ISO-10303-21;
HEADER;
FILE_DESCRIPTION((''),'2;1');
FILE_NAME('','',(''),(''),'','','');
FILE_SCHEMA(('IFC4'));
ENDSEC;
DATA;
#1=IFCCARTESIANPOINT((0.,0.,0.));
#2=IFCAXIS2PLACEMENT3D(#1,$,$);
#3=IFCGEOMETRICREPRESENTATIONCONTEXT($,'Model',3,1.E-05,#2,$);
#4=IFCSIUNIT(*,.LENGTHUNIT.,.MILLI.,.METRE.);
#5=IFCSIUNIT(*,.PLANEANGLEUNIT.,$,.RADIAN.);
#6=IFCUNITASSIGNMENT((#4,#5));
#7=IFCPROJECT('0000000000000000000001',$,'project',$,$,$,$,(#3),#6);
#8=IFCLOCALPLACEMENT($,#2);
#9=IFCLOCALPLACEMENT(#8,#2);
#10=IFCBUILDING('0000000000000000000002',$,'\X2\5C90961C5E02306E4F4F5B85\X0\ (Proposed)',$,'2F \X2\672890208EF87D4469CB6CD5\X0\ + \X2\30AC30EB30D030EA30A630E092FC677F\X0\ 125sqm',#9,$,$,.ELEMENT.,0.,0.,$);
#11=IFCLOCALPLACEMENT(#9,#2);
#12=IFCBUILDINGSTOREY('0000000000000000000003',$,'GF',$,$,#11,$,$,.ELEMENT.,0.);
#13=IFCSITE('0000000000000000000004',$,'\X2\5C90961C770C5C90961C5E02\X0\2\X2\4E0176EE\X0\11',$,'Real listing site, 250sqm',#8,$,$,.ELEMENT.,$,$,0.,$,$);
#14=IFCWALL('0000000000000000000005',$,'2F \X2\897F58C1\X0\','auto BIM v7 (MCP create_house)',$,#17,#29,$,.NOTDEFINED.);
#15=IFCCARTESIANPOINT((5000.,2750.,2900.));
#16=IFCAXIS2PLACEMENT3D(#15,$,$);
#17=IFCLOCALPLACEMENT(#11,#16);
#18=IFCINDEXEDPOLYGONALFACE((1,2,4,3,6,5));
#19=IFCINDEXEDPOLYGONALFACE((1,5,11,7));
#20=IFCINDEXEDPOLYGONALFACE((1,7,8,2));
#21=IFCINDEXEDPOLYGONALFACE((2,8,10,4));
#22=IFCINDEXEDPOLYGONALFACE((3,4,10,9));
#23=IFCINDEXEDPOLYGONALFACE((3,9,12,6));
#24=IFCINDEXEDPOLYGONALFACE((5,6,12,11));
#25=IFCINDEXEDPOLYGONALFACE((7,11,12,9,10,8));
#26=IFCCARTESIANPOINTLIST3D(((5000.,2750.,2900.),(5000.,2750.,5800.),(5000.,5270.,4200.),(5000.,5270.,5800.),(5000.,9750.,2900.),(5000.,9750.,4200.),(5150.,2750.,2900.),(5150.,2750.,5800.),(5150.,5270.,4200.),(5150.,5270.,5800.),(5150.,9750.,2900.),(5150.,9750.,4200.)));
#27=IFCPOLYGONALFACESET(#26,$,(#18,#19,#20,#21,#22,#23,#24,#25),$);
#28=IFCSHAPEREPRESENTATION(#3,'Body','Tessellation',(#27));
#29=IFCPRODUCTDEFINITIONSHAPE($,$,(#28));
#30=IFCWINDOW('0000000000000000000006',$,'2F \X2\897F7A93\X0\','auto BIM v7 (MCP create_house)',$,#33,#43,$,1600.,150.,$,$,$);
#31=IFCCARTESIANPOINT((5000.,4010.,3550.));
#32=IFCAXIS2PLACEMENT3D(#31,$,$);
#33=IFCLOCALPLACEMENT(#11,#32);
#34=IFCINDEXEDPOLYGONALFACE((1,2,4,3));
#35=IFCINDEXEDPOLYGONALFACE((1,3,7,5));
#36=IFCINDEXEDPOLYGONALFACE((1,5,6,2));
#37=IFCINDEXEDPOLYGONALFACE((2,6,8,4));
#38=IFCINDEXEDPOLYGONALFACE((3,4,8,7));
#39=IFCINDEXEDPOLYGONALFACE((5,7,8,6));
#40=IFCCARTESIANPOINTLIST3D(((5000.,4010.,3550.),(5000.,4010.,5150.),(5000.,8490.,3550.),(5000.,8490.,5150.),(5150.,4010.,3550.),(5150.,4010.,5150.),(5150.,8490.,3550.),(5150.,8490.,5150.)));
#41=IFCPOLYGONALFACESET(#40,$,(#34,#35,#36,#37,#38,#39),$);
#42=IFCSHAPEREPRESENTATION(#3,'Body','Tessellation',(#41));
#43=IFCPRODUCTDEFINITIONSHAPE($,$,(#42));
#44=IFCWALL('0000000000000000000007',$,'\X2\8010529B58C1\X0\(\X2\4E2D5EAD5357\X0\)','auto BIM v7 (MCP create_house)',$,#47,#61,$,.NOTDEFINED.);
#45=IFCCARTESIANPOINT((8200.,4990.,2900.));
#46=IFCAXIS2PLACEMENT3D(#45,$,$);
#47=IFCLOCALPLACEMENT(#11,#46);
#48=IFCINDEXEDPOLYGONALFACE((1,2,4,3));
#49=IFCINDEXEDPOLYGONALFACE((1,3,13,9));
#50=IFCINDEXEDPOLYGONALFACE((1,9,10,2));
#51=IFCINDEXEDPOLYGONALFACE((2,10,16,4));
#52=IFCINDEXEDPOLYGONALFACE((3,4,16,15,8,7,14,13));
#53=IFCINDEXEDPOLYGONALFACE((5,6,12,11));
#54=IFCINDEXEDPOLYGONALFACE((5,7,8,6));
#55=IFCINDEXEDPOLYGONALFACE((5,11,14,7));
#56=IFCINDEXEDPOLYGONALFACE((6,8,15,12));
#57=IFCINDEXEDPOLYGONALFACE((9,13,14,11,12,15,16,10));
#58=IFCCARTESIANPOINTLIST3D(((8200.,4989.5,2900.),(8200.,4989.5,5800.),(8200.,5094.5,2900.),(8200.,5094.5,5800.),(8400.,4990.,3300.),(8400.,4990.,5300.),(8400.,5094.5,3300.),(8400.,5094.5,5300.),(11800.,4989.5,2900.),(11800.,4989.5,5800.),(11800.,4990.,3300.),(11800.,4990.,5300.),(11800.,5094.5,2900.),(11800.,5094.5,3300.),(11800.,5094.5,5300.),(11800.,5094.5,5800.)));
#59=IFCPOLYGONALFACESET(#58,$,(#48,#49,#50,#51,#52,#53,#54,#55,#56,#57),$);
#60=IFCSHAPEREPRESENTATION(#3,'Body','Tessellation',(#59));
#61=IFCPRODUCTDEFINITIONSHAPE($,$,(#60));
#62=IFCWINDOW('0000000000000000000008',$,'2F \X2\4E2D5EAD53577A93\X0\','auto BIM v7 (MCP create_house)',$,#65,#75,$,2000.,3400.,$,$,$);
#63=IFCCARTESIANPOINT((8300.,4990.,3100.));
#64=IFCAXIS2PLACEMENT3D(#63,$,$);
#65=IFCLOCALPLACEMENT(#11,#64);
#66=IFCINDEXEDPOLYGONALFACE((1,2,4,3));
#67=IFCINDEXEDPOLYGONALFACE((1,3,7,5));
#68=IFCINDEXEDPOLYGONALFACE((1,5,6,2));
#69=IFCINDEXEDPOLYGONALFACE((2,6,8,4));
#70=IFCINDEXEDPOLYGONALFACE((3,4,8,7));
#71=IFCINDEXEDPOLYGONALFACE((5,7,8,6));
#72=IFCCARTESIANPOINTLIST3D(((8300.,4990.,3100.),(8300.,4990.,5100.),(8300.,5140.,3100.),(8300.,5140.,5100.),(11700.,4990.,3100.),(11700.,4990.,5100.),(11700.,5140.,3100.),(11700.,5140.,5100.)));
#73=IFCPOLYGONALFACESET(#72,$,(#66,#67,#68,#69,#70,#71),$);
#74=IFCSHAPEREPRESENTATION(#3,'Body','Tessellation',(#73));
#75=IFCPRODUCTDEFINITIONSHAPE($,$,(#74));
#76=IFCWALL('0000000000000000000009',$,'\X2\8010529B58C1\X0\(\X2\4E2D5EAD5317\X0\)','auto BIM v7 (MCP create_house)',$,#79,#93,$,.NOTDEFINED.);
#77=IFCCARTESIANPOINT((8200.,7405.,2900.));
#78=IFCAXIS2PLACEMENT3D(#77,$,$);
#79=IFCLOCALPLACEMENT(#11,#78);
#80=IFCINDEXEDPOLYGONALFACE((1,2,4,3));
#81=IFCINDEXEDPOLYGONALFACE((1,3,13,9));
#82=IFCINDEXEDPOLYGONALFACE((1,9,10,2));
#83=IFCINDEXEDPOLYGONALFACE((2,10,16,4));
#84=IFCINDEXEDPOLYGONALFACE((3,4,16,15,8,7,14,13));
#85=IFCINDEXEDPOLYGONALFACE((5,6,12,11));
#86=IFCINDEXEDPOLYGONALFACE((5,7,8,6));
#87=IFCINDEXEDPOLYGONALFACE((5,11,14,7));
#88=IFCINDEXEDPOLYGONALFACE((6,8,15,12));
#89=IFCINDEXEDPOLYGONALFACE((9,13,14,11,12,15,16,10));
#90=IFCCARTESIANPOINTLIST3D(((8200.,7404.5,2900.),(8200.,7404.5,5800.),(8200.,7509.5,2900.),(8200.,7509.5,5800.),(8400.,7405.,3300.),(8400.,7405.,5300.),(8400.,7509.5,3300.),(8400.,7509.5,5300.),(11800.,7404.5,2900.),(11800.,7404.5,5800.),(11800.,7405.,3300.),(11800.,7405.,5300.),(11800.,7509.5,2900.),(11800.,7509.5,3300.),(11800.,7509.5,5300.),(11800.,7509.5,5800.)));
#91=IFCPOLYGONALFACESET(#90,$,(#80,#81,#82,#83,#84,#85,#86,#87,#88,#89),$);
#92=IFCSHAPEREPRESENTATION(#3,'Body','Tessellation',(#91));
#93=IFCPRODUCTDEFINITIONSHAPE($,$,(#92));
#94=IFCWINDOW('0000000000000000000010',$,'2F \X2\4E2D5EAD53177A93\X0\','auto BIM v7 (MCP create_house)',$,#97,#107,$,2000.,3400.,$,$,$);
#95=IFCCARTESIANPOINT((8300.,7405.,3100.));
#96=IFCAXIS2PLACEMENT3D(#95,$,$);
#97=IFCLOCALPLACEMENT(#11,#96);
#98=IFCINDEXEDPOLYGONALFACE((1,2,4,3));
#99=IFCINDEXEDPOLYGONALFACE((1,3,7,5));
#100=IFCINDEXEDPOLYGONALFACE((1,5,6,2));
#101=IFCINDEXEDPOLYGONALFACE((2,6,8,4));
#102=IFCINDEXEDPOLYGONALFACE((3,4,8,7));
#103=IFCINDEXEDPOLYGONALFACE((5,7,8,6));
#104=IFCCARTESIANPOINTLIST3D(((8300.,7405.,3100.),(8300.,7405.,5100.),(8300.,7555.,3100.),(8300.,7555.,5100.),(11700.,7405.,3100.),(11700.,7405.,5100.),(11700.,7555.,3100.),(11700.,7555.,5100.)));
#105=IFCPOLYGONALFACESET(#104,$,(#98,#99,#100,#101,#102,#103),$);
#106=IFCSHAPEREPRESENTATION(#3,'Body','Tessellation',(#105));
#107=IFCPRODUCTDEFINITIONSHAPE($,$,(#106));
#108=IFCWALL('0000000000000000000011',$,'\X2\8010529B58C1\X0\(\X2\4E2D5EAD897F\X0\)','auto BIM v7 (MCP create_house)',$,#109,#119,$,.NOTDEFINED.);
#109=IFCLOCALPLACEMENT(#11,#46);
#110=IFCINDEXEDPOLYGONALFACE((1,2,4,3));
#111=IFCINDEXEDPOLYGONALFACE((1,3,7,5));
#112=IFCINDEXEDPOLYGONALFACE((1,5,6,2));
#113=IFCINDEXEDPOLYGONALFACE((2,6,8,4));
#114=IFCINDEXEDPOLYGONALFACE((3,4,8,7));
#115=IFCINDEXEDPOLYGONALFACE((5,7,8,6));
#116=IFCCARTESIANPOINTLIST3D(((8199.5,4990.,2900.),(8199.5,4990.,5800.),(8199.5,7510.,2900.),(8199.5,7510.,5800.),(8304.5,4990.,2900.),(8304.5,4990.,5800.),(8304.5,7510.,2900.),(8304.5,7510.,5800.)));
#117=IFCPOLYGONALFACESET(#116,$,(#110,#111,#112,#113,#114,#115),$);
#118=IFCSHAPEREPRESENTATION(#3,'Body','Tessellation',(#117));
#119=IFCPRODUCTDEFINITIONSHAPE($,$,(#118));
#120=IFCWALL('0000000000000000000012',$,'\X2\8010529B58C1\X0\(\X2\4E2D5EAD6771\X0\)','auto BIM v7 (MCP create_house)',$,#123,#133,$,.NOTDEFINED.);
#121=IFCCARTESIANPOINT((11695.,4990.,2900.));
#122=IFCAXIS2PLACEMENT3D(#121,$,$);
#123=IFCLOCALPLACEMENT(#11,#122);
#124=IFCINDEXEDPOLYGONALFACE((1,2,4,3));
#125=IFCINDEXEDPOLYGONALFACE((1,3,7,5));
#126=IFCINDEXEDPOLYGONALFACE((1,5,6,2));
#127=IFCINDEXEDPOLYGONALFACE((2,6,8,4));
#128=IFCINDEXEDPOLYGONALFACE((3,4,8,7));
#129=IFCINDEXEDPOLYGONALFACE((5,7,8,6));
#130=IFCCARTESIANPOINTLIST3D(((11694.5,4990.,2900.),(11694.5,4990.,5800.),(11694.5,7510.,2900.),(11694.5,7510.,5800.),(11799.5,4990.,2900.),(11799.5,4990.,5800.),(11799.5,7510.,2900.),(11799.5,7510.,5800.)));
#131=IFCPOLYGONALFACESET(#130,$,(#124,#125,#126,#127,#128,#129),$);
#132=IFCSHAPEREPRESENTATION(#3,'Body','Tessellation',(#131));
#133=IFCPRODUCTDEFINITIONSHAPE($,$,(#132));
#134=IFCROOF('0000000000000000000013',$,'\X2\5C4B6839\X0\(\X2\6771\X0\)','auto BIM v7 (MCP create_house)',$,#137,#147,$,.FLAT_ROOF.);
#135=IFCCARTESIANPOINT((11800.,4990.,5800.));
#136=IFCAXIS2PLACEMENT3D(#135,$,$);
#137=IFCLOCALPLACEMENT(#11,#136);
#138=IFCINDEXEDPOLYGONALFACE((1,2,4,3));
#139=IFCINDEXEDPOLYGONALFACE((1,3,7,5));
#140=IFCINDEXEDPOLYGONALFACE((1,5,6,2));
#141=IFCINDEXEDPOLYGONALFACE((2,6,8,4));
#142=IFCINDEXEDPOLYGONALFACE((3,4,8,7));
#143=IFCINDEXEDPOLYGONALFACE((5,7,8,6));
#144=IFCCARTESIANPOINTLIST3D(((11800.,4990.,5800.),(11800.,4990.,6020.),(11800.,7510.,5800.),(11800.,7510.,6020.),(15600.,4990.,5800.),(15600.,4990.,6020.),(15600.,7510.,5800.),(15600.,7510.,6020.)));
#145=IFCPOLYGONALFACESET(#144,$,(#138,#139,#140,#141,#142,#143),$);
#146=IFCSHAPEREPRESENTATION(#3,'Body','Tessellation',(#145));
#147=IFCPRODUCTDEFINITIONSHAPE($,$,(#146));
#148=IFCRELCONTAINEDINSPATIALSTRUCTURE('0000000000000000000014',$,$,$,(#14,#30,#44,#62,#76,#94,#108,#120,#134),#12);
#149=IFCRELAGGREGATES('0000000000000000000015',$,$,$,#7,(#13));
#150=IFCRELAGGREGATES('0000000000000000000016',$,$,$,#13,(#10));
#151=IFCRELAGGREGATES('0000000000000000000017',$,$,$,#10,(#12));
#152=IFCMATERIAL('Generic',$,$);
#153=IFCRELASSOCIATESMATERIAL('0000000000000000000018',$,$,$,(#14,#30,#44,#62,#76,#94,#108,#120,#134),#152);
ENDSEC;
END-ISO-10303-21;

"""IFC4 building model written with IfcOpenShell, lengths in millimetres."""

from ifc_helpers import new_model, si_unit, frame, frame_2d, origin, place, context, project, spatial, rectangle, extrude, material, element, fill, save


model = new_model("IFC4")

# Units and contexts
model_context = context("Model", 3, precision=1e-05, world=origin())
ifc_project = project(units=[si_unit("LENGTHUNIT", "METRE", prefix="MILLI"), si_unit("PLANEANGLEUNIT", "RADIAN")], contexts=[model_context])

# Site, building, storey
site_placement = place(None, origin())
site = spatial("IfcSite", under=ifc_project, at=site_placement, Name="岐阜県岐阜市2丁目11", ObjectType="Real listing site, 250sqm", CompositionType="ELEMENT", RefElevation=0.0)
building_placement = place(site_placement, origin())
building = spatial("IfcBuilding", under=site, at=building_placement, Name="岐阜市の住宅 (Proposed)", ObjectType="2F 木造軸組構法 + ガルバリウム鋼板 125sqm", CompositionType="ELEMENT", ElevationOfRefHeight=0.0, ElevationOfTerrain=0.0)
storey_placement = place(building_placement, origin())
storey = spatial("IfcBuildingStorey", under=building, at=storey_placement, Name="GF", CompositionType="ELEMENT", Elevation=0.0)

# Shared definitions
ifc_material = material(Name="Generic")

# Walls, openings, windows
wall_1_placement = place(storey_placement, frame((5000.0, 2750.0, 2900.0)))
wall_1 = element("IfcWall", 1, at=wall_1_placement, inside=storey, material=ifc_material, Name="2F 西壁", Description="auto BIM v7 (MCP create_house)", PredefinedType="NOTDEFINED", context=model_context, shape_type="SweptSolid", body=[
    extrude(rectangle(XDim=150.0, YDim=7000.0, at=frame_2d((75.0, 3500.0))), frame((5000.0, 2750.0, 2900.0)), (0.0, 0.0, 1.0), 2900.0),
])
opening_1_placement = place(storey_placement, frame((5000.0, 4010.0, 3550.0)))
opening_1 = element("IfcOpeningElement", 2, at=opening_1_placement, cuts=wall_1, PredefinedType="NOTDEFINED", context=model_context, shape_type="SweptSolid", body=[
    extrude(rectangle(XDim=150.0, YDim=4480.0, at=frame_2d((75.0, 2240.0))), frame((5000.0, 4010.0, 3550.0)), (0.0, 0.0, 1.0), 1600.0),
])
window_1_placement = place(storey_placement, frame((5000.0, 4010.0, 3550.0)))
window_1 = element("IfcWindow", 3, at=window_1_placement, inside=storey, material=ifc_material, Name="2F 西窓", Description="auto BIM v7 (MCP create_house)", OverallHeight=1600.0, OverallWidth=150.0, context=model_context, shape_type="SweptSolid", body=[
    extrude(rectangle(XDim=150.0, YDim=4480.0, at=frame_2d((75.0, 2240.0))), frame((5000.0, 4010.0, 3550.0)), (0.0, 0.0, 1.0), 1600.0),
])
fill(opening_1, window_1)
wall_2_placement = place(storey_placement, frame((8200.0, 4990.0, 2900.0)))
wall_2 = element("IfcWall", 4, at=wall_2_placement, inside=storey, material=ifc_material, Name="耐力壁(中庭南)", Description="auto BIM v7 (MCP create_house)", PredefinedType="NOTDEFINED", context=model_context, shape_type="SweptSolid", body=[
    extrude(rectangle(XDim=3600.0, YDim=105.0, at=frame_2d((1800.0, 52.0))), frame((8200.0, 4990.0, 2900.0)), (0.0, 0.0, 1.0), 2900.0),
])
opening_2_placement = place(storey_placement, frame((8300.0, 4990.0, 3100.0)))
opening_2 = element("IfcOpeningElement", 5, at=opening_2_placement, cuts=wall_2, PredefinedType="NOTDEFINED", context=model_context, shape_type="SweptSolid", body=[
    extrude(rectangle(XDim=3400.0, YDim=150.0, at=frame_2d((1700.0, 75.0))), frame((8300.0, 4990.0, 3100.0)), (0.0, 0.0, 1.0), 2000.0),
])
window_2_placement = place(storey_placement, frame((8300.0, 4990.0, 3100.0)))
window_2 = element("IfcWindow", 6, at=window_2_placement, inside=storey, material=ifc_material, Name="2F 中庭南窓", Description="auto BIM v7 (MCP create_house)", OverallHeight=2000.0, OverallWidth=3400.0, context=model_context, shape_type="SweptSolid", body=[
    extrude(rectangle(XDim=3400.0, YDim=150.0, at=frame_2d((1700.0, 75.0))), frame((8300.0, 4990.0, 3100.0)), (0.0, 0.0, 1.0), 2000.0),
])
fill(opening_2, window_2)
wall_3_placement = place(storey_placement, frame((8200.0, 7405.0, 2900.0)))
wall_3 = element("IfcWall", 7, at=wall_3_placement, inside=storey, material=ifc_material, Name="耐力壁(中庭北)", Description="auto BIM v7 (MCP create_house)", PredefinedType="NOTDEFINED", context=model_context, shape_type="SweptSolid", body=[
    extrude(rectangle(XDim=3600.0, YDim=105.0, at=frame_2d((1800.0, 52.0))), frame((8200.0, 7405.0, 2900.0)), (0.0, 0.0, 1.0), 2900.0),
])
opening_3_placement = place(storey_placement, frame((8300.0, 7405.0, 3100.0)))
opening_3 = element("IfcOpeningElement", 8, at=opening_3_placement, cuts=wall_3, PredefinedType="NOTDEFINED", context=model_context, shape_type="SweptSolid", body=[
    extrude(rectangle(XDim=3400.0, YDim=150.0, at=frame_2d((1700.0, 75.0))), frame((8300.0, 7405.0, 3100.0)), (0.0, 0.0, 1.0), 2000.0),
])
window_3_placement = place(storey_placement, frame((8300.0, 7405.0, 3100.0)))
window_3 = element("IfcWindow", 9, at=window_3_placement, inside=storey, material=ifc_material, Name="2F 中庭北窓", Description="auto BIM v7 (MCP create_house)", OverallHeight=2000.0, OverallWidth=3400.0, context=model_context, shape_type="SweptSolid", body=[
    extrude(rectangle(XDim=3400.0, YDim=150.0, at=frame_2d((1700.0, 75.0))), frame((8300.0, 7405.0, 3100.0)), (0.0, 0.0, 1.0), 2000.0),
])
fill(opening_3, window_3)

# Walls
wall_4_placement = place(storey_placement, frame((8200.0, 4990.0, 2900.0)))
element("IfcWall", 10, at=wall_4_placement, inside=storey, material=ifc_material, Name="耐力壁(中庭西)", Description="auto BIM v7 (MCP create_house)", PredefinedType="NOTDEFINED", context=model_context, shape_type="SweptSolid", body=[
    extrude(rectangle(XDim=105.0, YDim=2520.0, at=frame_2d((52.0, 1260.0))), frame((8200.0, 4990.0, 2900.0)), (0.0, 0.0, 1.0), 2900.0),
])
wall_5_placement = place(storey_placement, frame((11695.0, 4990.0, 2900.0)))
element("IfcWall", 11, at=wall_5_placement, inside=storey, material=ifc_material, Name="耐力壁(中庭東)", Description="auto BIM v7 (MCP create_house)", PredefinedType="NOTDEFINED", context=model_context, shape_type="SweptSolid", body=[
    extrude(rectangle(XDim=105.0, YDim=2520.0, at=frame_2d((52.0, 1260.0))), frame((11695.0, 4990.0, 2900.0)), (0.0, 0.0, 1.0), 2900.0),
])

# Roof
for number, where, name in (
    (12, (11800.0, 4990.0, 5800.0), "屋根(東)"),
):
    element("IfcRoof", number, at=place(storey_placement, frame(where)), inside=storey, material=ifc_material, Name=name, Description="auto BIM v7 (MCP create_house)", PredefinedType="FLAT_ROOF", context=model_context, shape_type="SweptSolid", body=[
        extrude(rectangle(XDim=3800.0, YDim=2520.0, at=frame_2d((1900.0, 1260.0))), frame((11800.0, 4990.0, 5800.0)), (0.0, 0.0, 1.0), 220.0),
    ])

save(model, "model.ifc")
